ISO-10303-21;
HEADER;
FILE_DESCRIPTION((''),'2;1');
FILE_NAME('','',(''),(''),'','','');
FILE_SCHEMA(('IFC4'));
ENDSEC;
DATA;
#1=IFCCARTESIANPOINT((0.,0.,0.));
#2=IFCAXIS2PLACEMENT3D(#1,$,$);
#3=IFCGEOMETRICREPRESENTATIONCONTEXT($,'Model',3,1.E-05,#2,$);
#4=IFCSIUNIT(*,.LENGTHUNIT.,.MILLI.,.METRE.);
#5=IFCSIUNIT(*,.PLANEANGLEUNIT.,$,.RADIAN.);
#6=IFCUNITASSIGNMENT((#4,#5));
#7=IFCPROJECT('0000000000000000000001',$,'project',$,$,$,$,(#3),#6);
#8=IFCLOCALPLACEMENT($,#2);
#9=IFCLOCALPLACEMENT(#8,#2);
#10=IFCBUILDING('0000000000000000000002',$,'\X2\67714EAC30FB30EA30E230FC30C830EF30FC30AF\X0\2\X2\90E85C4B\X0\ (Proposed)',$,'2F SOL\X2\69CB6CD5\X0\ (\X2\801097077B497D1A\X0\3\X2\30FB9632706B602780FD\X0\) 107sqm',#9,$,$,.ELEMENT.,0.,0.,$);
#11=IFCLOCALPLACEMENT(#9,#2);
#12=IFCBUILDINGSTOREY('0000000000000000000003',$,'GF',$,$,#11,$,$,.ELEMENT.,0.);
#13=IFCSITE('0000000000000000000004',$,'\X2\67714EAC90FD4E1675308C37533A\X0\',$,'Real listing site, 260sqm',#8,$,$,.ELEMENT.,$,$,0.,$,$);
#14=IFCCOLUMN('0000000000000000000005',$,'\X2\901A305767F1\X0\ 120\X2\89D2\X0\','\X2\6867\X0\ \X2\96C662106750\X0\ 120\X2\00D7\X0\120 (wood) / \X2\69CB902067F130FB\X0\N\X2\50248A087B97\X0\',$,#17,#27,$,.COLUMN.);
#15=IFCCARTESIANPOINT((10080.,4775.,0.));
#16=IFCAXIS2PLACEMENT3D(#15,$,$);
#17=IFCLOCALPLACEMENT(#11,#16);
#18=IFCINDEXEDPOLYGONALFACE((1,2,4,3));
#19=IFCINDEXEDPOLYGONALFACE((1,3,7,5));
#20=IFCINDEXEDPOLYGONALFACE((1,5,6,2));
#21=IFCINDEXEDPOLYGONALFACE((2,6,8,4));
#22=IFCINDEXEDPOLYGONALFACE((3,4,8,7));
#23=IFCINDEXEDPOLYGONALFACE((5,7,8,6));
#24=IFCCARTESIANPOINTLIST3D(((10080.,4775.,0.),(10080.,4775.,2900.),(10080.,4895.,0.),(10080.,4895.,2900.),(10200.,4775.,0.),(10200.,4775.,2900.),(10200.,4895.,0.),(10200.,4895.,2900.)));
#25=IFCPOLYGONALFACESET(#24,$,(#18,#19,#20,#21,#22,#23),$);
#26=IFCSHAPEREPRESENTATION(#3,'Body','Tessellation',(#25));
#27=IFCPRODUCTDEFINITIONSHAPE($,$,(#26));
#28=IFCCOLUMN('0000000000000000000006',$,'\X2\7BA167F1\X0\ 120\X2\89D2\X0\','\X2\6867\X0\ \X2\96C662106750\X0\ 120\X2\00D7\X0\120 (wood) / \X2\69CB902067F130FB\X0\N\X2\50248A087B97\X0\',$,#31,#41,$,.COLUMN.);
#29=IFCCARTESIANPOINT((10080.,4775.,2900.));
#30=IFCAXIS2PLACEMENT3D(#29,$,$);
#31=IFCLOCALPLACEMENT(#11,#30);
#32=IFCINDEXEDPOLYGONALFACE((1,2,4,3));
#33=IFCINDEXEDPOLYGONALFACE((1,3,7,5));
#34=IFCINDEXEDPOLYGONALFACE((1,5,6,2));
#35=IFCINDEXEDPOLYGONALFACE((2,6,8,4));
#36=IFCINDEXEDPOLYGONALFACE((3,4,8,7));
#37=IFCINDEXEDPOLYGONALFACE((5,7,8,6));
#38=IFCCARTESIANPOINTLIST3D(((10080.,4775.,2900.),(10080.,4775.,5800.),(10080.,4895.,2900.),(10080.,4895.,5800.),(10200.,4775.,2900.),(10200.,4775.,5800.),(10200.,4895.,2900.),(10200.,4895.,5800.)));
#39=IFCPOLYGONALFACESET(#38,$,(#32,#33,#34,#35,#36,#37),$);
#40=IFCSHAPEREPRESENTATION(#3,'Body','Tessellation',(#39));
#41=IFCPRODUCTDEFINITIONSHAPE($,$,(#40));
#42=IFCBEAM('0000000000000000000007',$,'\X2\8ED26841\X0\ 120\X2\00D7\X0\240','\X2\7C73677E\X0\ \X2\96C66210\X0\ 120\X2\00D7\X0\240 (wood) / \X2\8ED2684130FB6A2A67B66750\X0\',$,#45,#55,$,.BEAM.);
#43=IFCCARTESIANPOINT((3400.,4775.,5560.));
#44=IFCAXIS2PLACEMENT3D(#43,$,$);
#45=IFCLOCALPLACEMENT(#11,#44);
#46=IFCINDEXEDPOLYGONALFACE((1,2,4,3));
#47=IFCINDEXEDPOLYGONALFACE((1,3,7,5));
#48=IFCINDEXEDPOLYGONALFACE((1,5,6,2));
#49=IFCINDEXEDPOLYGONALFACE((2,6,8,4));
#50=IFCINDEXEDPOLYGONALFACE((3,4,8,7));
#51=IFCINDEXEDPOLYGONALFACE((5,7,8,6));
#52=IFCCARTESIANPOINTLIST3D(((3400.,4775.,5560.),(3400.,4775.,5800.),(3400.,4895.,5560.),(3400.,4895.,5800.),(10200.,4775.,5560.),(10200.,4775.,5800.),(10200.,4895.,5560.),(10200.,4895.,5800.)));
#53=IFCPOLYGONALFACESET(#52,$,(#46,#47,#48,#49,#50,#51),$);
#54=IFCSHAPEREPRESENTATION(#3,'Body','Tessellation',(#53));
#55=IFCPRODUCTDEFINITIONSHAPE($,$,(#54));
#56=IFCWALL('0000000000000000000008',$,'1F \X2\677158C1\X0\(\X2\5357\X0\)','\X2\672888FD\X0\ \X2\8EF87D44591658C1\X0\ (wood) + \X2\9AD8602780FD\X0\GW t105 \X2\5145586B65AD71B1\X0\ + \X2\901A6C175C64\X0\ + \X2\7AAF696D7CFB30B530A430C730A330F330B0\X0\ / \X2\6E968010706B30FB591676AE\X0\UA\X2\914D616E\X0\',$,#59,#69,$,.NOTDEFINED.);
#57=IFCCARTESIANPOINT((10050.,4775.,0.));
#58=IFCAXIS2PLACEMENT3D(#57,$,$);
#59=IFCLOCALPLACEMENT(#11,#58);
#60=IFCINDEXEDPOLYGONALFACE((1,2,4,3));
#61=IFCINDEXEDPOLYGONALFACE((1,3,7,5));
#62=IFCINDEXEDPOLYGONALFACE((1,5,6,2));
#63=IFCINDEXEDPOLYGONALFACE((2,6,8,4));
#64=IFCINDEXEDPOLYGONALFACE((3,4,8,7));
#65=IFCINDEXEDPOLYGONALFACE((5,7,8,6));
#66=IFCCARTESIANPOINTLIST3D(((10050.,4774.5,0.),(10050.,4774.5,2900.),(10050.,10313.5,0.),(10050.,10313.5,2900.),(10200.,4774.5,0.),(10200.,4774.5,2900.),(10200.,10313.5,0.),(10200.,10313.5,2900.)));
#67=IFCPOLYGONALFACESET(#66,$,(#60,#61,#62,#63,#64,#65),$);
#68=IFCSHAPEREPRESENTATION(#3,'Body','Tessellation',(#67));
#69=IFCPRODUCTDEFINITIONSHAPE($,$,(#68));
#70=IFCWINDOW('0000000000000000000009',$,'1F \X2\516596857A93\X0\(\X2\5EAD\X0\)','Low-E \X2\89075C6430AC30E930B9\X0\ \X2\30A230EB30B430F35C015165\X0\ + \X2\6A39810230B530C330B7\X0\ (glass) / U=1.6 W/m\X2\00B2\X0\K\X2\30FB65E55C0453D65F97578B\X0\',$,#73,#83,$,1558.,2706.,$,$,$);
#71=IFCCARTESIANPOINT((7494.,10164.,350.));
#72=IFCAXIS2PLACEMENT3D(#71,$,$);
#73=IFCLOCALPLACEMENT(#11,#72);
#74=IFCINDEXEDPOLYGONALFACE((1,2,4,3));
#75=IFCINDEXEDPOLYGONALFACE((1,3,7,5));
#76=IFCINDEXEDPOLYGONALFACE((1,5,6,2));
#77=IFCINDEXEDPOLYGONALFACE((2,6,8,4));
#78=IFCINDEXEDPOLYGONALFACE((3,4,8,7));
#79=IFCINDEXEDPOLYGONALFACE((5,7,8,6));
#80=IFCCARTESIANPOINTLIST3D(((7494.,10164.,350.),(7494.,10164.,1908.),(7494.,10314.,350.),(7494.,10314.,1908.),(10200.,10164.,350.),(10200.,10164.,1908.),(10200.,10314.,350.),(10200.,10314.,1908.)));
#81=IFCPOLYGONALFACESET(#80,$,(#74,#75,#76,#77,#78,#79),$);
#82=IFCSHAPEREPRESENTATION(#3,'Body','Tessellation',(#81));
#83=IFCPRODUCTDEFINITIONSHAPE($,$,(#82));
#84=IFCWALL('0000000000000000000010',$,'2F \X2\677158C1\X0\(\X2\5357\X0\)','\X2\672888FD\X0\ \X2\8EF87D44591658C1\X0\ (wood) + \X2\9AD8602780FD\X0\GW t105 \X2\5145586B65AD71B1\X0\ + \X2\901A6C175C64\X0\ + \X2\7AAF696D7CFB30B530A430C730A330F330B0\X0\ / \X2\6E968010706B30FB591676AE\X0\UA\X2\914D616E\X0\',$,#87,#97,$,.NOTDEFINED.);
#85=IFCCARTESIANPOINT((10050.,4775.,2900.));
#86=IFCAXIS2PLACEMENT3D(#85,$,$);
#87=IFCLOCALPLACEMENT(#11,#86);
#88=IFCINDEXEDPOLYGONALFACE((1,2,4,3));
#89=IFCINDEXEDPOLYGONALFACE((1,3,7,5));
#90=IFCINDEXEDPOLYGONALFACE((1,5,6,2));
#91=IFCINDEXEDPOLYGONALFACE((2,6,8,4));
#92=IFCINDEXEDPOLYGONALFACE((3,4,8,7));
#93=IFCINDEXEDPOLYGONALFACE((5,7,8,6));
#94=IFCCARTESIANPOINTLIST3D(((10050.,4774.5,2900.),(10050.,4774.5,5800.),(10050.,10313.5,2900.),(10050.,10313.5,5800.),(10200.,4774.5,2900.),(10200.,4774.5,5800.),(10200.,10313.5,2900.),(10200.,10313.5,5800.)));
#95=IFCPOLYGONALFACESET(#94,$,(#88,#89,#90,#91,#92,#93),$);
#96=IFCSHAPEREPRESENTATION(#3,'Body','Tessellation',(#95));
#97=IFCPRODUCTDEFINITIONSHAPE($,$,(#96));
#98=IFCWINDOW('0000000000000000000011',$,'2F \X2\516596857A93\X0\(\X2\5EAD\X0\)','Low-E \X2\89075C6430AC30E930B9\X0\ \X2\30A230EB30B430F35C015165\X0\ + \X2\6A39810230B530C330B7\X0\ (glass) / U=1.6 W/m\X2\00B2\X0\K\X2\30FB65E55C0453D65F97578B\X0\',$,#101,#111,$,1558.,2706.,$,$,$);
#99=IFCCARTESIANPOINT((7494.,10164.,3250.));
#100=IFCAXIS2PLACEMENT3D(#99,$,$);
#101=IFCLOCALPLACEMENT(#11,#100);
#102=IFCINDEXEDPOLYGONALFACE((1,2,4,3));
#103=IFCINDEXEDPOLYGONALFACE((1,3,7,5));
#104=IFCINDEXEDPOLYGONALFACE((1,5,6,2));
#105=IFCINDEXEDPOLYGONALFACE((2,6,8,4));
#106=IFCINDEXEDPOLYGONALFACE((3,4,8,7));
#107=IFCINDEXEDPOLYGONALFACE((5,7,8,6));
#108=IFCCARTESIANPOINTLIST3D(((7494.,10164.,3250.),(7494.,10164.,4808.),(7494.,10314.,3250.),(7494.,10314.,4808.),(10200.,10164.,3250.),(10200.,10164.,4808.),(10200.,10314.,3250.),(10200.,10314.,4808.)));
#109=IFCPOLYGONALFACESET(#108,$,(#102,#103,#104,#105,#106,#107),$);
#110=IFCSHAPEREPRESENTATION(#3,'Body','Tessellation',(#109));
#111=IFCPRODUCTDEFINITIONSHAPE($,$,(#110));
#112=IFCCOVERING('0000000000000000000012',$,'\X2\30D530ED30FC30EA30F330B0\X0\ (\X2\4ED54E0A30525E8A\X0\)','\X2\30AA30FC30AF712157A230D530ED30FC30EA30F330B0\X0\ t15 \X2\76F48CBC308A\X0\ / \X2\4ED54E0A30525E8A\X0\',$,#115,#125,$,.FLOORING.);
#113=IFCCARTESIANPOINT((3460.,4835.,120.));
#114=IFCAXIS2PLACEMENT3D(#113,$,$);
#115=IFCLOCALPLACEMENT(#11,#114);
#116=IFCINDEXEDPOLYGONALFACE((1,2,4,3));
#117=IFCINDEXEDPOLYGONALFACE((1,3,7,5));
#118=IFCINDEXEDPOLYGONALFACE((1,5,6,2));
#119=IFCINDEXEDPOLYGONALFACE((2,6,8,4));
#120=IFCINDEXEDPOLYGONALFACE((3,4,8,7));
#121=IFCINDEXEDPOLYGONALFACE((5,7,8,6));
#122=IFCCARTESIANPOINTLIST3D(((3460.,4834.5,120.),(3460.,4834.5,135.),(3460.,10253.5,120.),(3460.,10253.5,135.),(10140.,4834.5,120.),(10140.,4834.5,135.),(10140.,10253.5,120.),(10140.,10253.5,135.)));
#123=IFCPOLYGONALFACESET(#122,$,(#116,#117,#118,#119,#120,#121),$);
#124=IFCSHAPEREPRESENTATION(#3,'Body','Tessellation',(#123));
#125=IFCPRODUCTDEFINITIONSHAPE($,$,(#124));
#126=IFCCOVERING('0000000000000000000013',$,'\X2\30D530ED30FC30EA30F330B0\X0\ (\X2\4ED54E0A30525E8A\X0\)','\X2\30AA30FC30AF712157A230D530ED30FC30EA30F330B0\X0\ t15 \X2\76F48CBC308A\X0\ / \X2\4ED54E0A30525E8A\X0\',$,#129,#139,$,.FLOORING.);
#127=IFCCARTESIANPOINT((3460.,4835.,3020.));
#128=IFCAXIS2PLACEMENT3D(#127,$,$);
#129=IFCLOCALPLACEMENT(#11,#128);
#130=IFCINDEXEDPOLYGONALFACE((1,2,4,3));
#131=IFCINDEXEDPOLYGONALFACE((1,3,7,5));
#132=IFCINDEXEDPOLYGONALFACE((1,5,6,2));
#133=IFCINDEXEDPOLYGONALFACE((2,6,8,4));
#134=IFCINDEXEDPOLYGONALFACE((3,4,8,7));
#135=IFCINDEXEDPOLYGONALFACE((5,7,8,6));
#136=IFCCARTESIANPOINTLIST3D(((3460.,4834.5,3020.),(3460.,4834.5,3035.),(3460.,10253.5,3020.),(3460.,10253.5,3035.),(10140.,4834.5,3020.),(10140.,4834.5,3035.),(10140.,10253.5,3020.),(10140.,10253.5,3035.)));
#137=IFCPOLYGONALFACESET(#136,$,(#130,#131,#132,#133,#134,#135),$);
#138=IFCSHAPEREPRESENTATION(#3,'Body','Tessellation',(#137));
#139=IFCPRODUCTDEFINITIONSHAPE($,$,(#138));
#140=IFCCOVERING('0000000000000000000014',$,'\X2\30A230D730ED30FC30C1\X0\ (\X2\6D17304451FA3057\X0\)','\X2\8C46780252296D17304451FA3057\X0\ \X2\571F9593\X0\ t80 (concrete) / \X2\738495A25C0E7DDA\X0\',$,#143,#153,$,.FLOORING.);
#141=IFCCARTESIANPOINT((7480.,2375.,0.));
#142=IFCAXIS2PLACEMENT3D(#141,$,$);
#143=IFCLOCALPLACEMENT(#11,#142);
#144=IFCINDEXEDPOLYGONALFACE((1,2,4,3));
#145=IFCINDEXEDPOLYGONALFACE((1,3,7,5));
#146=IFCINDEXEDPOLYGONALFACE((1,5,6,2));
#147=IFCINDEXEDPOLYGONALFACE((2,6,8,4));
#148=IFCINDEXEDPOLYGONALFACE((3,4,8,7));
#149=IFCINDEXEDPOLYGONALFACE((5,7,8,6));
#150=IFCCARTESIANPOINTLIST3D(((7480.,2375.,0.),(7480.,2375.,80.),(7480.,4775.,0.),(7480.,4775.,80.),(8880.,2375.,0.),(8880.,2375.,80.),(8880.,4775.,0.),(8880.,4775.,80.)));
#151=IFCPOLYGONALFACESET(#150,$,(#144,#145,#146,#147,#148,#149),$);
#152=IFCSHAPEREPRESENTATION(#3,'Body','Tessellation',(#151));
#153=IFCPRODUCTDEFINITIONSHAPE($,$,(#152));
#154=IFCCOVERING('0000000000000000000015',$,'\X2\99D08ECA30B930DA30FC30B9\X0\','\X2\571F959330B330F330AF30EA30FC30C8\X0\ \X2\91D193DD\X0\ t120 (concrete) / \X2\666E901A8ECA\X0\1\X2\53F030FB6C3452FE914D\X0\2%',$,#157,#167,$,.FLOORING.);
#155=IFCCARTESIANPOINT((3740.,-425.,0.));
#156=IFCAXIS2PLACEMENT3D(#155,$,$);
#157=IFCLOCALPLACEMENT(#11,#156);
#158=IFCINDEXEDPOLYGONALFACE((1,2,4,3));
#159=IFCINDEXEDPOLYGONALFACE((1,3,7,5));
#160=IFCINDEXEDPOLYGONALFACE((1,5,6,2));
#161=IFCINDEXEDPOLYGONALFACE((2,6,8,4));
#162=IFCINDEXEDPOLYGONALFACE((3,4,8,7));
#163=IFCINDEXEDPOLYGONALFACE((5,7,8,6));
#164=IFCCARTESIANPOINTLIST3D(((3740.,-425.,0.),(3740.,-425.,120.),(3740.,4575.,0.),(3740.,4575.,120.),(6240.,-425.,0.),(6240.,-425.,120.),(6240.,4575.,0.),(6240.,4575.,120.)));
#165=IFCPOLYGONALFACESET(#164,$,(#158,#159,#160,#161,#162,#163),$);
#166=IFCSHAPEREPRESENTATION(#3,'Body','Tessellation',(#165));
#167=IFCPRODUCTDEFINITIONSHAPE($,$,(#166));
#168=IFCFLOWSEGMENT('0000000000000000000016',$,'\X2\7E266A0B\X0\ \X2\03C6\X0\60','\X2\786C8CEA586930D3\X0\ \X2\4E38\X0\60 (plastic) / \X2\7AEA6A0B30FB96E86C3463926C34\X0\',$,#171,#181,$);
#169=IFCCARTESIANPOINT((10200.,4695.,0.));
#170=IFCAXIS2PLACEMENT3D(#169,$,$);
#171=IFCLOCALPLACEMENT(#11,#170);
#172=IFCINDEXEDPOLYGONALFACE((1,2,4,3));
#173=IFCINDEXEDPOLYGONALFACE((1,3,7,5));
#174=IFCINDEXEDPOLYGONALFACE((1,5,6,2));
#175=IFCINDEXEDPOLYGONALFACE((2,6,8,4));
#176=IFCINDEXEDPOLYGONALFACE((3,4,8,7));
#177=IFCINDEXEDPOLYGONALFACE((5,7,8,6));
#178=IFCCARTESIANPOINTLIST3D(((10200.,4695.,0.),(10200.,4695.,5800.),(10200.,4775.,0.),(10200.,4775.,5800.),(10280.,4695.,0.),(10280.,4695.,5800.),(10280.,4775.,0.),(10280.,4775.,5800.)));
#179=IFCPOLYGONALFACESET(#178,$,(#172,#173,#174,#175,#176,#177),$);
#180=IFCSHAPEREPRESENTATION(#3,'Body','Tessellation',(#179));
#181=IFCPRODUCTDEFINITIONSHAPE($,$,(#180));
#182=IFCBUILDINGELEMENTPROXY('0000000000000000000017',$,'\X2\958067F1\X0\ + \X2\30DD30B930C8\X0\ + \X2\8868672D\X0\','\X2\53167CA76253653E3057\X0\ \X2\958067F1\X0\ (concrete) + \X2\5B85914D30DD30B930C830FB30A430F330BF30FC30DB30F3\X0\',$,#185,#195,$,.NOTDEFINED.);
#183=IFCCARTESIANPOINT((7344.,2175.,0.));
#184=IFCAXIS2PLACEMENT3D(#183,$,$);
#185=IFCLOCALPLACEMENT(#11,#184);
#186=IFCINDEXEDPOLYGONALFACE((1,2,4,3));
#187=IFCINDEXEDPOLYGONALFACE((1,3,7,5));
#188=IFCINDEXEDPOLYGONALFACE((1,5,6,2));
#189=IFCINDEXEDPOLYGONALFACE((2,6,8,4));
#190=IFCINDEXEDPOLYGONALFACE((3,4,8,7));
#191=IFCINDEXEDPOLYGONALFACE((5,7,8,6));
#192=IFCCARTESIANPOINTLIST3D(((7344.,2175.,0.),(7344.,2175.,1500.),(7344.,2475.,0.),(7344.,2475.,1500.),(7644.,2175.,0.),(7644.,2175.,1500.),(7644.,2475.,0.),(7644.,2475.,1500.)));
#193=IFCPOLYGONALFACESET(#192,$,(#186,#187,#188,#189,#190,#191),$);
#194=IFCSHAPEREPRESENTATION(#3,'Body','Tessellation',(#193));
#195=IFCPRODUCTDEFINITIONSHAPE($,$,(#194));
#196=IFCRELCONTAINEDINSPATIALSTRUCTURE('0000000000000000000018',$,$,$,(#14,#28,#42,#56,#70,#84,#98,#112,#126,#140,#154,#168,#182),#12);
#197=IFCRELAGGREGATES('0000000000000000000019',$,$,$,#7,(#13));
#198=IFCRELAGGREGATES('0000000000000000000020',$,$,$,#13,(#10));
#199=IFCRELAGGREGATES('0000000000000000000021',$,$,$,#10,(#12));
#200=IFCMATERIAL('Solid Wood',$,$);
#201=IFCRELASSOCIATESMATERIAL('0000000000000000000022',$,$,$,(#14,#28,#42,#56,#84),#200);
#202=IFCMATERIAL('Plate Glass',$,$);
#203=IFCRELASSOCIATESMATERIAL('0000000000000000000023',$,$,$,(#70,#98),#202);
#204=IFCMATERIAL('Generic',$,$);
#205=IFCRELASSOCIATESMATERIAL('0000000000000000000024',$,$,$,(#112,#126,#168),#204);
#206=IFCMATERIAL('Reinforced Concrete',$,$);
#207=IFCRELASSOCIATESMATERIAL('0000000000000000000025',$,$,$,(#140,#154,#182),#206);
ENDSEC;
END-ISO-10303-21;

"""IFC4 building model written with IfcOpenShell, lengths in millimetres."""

from ifc_helpers import new_model, si_unit, frame, frame_2d, origin, place, context, project, spatial, rectangle, extrude, material, element, fill, save


model = new_model("IFC4")

# Units and contexts
model_context = context("Model", 3, precision=1e-05, world=origin())
ifc_project = project(units=[si_unit("LENGTHUNIT", "METRE", prefix="MILLI"), si_unit("PLANEANGLEUNIT", "RADIAN")], contexts=[model_context])

# Site, building, storey
site_placement = place(None, origin())
site = spatial("IfcSite", under=ifc_project, at=site_placement, Name="東京都世田谷区", ObjectType="Real listing site, 260sqm", CompositionType="ELEMENT", RefElevation=0.0)
building_placement = place(site_placement, origin())
building = spatial("IfcBuilding", under=site, at=building_placement, Name="東京・リモートワーク2部屋 (Proposed)", ObjectType="2F SOL構法 (耐震等級3・防火性能) 107sqm", CompositionType="ELEMENT", ElevationOfRefHeight=0.0, ElevationOfTerrain=0.0)
storey_placement = place(building_placement, origin())
storey = spatial("IfcBuildingStorey", under=building, at=storey_placement, Name="GF", CompositionType="ELEMENT", Elevation=0.0)

# Columns
ifc_material_1 = material(Name="Solid Wood")
column_1_placement = place(storey_placement, frame((10080.0, 4775.0, 0.0)))
element("IfcColumn", 1, at=column_1_placement, inside=storey, material=ifc_material_1, Name="通し柱 120角", Description="桧 集成材 120×120 (wood) / 構造柱・N値計算", PredefinedType="COLUMN", context=model_context, shape_type="SweptSolid", body=[
    extrude(rectangle(XDim=120.0, YDim=120.0, at=frame_2d((60.0, 60.0))), frame((10080.0, 4775.0, 0.0)), (0.0, 0.0, 1.0), 2900.0),
])
column_2_placement = place(storey_placement, frame((10080.0, 4775.0, 2900.0)))
element("IfcColumn", 2, at=column_2_placement, inside=storey, material=ifc_material_1, Name="管柱 120角", Description="桧 集成材 120×120 (wood) / 構造柱・N値計算", PredefinedType="COLUMN", context=model_context, shape_type="SweptSolid", body=[
    extrude(rectangle(XDim=120.0, YDim=120.0, at=frame_2d((60.0, 60.0))), frame((10080.0, 4775.0, 2900.0)), (0.0, 0.0, 1.0), 2900.0),
])

# Beam
beam_1_placement = place(storey_placement, frame((3400.0, 4775.0, 5560.0)))
element("IfcBeam", 3, at=beam_1_placement, inside=storey, material=ifc_material_1, Name="軒桁 120×240", Description="米松 集成 120×240 (wood) / 軒桁・横架材", PredefinedType="BEAM", context=model_context, shape_type="SweptSolid", body=[
    extrude(rectangle(XDim=6800.0, YDim=120.0, at=frame_2d((3400.0, 60.0))), frame((3400.0, 4775.0, 5560.0)), (0.0, 0.0, 1.0), 240.0),
])

# Wall, opening, window
wall_1_placement = place(storey_placement, frame((10050.0, 4775.0, 0.0)))
wall_1 = element("IfcWall", 4, at=wall_1_placement, inside=storey, material=ifc_material_1, Name="1F 東壁(南)", Description="木製 軸組外壁 (wood) + 高性能GW t105 充填断熱 + 通気層 + 窯業系サイディング / 準耐火・外皮UA配慮", PredefinedType="NOTDEFINED", context=model_context, shape_type="SweptSolid", body=[
    extrude(rectangle(XDim=150.0, YDim=5539.0, at=frame_2d((75.0, 2769.0))), frame((10050.0, 4775.0, 0.0)), (0.0, 0.0, 1.0), 2900.0),
])
opening_1_placement = place(storey_placement, frame((7494.0, 10164.0, 350.0)))
opening_1 = element("IfcOpeningElement", 5, at=opening_1_placement, cuts=wall_1, PredefinedType="NOTDEFINED", context=model_context, shape_type="SweptSolid", body=[
    extrude(rectangle(XDim=2706.0, YDim=150.0, at=frame_2d((1353.0, 75.0))), frame((7494.0, 10164.0, 350.0)), (0.0, 0.0, 1.0), 1558.0),
])
ifc_material_2 = material(Name="Plate Glass")
window_1_placement = place(storey_placement, frame((7494.0, 10164.0, 350.0)))
window_1 = element("IfcWindow", 6, at=window_1_placement, inside=storey, material=ifc_material_2, Name="1F 入隅窓(庭)", Description="Low-E 複層ガラス アルゴン封入 + 樹脂サッシ (glass) / U=1.6 W/m²K・日射取得型", OverallHeight=1558.0, OverallWidth=2706.0, context=model_context, shape_type="SweptSolid", body=[
    extrude(rectangle(XDim=2706.0, YDim=150.0, at=frame_2d((1353.0, 75.0))), frame((7494.0, 10164.0, 350.0)), (0.0, 0.0, 1.0), 1558.0),
])
fill(opening_1, window_1)

# Wall, opening, window
wall_2_placement = place(storey_placement, frame((10050.0, 4775.0, 2900.0)))
wall_2 = element("IfcWall", 7, at=wall_2_placement, inside=storey, material=ifc_material_1, Name="2F 東壁(南)", Description="木製 軸組外壁 (wood) + 高性能GW t105 充填断熱 + 通気層 + 窯業系サイディング / 準耐火・外皮UA配慮", PredefinedType="NOTDEFINED", context=model_context, shape_type="SweptSolid", body=[
    extrude(rectangle(XDim=150.0, YDim=5539.0, at=frame_2d((75.0, 2769.0))), frame((10050.0, 4775.0, 2900.0)), (0.0, 0.0, 1.0), 2900.0),
])
opening_2_placement = place(storey_placement, frame((7494.0, 10164.0, 3250.0)))
opening_2 = element("IfcOpeningElement", 8, at=opening_2_placement, cuts=wall_2, PredefinedType="NOTDEFINED", context=model_context, shape_type="SweptSolid", body=[
    extrude(rectangle(XDim=2706.0, YDim=150.0, at=frame_2d((1353.0, 75.0))), frame((7494.0, 10164.0, 3250.0)), (0.0, 0.0, 1.0), 1558.0),
])
window_2_placement = place(storey_placement, frame((7494.0, 10164.0, 3250.0)))
window_2 = element("IfcWindow", 9, at=window_2_placement, inside=storey, material=ifc_material_2, Name="2F 入隅窓(庭)", Description="Low-E 複層ガラス アルゴン封入 + 樹脂サッシ (glass) / U=1.6 W/m²K・日射取得型", OverallHeight=1558.0, OverallWidth=2706.0, context=model_context, shape_type="SweptSolid", body=[
    extrude(rectangle(XDim=2706.0, YDim=150.0, at=frame_2d((1353.0, 75.0))), frame((7494.0, 10164.0, 3250.0)), (0.0, 0.0, 1.0), 1558.0),
])
fill(opening_2, window_2)

# Coverings
ifc_material_3 = material(Name="Generic")
covering_1_placement = place(storey_placement, frame((3460.0, 4835.0, 120.0)))
element("IfcCovering", 10, at=covering_1_placement, inside=storey, material=ifc_material_3, Name="フローリング (仕上げ床)", Description="オーク無垢フローリング t15 直貼り / 仕上げ床", PredefinedType="FLOORING", context=model_context, shape_type="SweptSolid", body=[
    extrude(rectangle(XDim=6680.0, YDim=5419.0, at=frame_2d((3340.0, 2709.0))), frame((3460.0, 4835.0, 120.0)), (0.0, 0.0, 1.0), 15.0),
])
covering_2_placement = place(storey_placement, frame((3460.0, 4835.0, 3020.0)))
element("IfcCovering", 11, at=covering_2_placement, inside=storey, material=ifc_material_3, Name="フローリング (仕上げ床)", Description="オーク無垢フローリング t15 直貼り / 仕上げ床", PredefinedType="FLOORING", context=model_context, shape_type="SweptSolid", body=[
    extrude(rectangle(XDim=6680.0, YDim=5419.0, at=frame_2d((3340.0, 2709.0))), frame((3460.0, 4835.0, 3020.0)), (0.0, 0.0, 1.0), 15.0),
])
ifc_material_4 = material(Name="Reinforced Concrete")
covering_3_placement = place(storey_placement, frame((7480.0, 2375.0, 0.0)))
element("IfcCovering", 12, at=covering_3_placement, inside=storey, material=ifc_material_4, Name="アプローチ (洗い出し)", Description="豆砂利洗い出し 土間 t80 (concrete) / 玄関導線", PredefinedType="FLOORING", context=model_context, shape_type="SweptSolid", body=[
    extrude(rectangle(XDim=1400.0, YDim=2400.0, at=frame_2d((700.0, 1200.0))), frame((7480.0, 2375.0, 0.0)), (0.0, 0.0, 1.0), 80.0),
])
covering_4_placement = place(storey_placement, frame((3740.0, -425.0, 0.0)))
element("IfcCovering", 13, at=covering_4_placement, inside=storey, material=ifc_material_4, Name="駐車スペース", Description="土間コンクリート 金鏝 t120 (concrete) / 普通車1台・水勾配2%", PredefinedType="FLOORING", context=model_context, shape_type="SweptSolid", body=[
    extrude(rectangle(XDim=2500.0, YDim=5000.0, at=frame_2d((1250.0, 2500.0))), frame((3740.0, -425.0, 0.0)), (0.0, 0.0, 1.0), 120.0),
])

# Flow segment
flow_segment_placement = place(storey_placement, frame((10200.0, 4695.0, 0.0)))
element("IfcFlowSegment", 14, at=flow_segment_placement, inside=storey, material=ifc_material_3, Name="縦樋 φ60", Description="硬質塩ビ 丸60 (plastic) / 竪樋・雨水排水", context=model_context, shape_type="SweptSolid", body=[
    extrude(rectangle(XDim=80.0, YDim=80.0, at=frame_2d((40.0, 40.0))), frame((10200.0, 4695.0, 0.0)), (0.0, 0.0, 1.0), 5800.0),
])

# Building element proxy
proxy_placement = place(storey_placement, frame((7344.0, 2175.0, 0.0)))
element("IfcBuildingElementProxy", 15, at=proxy_placement, inside=storey, material=ifc_material_4, Name="門柱 + ポスト + 表札", Description="化粧打放し 門柱 (concrete) + 宅配ポスト・インターホン", PredefinedType="NOTDEFINED", context=model_context, shape_type="SweptSolid", body=[
    extrude(rectangle(XDim=300.0, YDim=300.0, at=frame_2d((150.0, 150.0))), frame((7344.0, 2175.0, 0.0)), (0.0, 0.0, 1.0), 1500.0),
])

save(model, "model.ifc")
